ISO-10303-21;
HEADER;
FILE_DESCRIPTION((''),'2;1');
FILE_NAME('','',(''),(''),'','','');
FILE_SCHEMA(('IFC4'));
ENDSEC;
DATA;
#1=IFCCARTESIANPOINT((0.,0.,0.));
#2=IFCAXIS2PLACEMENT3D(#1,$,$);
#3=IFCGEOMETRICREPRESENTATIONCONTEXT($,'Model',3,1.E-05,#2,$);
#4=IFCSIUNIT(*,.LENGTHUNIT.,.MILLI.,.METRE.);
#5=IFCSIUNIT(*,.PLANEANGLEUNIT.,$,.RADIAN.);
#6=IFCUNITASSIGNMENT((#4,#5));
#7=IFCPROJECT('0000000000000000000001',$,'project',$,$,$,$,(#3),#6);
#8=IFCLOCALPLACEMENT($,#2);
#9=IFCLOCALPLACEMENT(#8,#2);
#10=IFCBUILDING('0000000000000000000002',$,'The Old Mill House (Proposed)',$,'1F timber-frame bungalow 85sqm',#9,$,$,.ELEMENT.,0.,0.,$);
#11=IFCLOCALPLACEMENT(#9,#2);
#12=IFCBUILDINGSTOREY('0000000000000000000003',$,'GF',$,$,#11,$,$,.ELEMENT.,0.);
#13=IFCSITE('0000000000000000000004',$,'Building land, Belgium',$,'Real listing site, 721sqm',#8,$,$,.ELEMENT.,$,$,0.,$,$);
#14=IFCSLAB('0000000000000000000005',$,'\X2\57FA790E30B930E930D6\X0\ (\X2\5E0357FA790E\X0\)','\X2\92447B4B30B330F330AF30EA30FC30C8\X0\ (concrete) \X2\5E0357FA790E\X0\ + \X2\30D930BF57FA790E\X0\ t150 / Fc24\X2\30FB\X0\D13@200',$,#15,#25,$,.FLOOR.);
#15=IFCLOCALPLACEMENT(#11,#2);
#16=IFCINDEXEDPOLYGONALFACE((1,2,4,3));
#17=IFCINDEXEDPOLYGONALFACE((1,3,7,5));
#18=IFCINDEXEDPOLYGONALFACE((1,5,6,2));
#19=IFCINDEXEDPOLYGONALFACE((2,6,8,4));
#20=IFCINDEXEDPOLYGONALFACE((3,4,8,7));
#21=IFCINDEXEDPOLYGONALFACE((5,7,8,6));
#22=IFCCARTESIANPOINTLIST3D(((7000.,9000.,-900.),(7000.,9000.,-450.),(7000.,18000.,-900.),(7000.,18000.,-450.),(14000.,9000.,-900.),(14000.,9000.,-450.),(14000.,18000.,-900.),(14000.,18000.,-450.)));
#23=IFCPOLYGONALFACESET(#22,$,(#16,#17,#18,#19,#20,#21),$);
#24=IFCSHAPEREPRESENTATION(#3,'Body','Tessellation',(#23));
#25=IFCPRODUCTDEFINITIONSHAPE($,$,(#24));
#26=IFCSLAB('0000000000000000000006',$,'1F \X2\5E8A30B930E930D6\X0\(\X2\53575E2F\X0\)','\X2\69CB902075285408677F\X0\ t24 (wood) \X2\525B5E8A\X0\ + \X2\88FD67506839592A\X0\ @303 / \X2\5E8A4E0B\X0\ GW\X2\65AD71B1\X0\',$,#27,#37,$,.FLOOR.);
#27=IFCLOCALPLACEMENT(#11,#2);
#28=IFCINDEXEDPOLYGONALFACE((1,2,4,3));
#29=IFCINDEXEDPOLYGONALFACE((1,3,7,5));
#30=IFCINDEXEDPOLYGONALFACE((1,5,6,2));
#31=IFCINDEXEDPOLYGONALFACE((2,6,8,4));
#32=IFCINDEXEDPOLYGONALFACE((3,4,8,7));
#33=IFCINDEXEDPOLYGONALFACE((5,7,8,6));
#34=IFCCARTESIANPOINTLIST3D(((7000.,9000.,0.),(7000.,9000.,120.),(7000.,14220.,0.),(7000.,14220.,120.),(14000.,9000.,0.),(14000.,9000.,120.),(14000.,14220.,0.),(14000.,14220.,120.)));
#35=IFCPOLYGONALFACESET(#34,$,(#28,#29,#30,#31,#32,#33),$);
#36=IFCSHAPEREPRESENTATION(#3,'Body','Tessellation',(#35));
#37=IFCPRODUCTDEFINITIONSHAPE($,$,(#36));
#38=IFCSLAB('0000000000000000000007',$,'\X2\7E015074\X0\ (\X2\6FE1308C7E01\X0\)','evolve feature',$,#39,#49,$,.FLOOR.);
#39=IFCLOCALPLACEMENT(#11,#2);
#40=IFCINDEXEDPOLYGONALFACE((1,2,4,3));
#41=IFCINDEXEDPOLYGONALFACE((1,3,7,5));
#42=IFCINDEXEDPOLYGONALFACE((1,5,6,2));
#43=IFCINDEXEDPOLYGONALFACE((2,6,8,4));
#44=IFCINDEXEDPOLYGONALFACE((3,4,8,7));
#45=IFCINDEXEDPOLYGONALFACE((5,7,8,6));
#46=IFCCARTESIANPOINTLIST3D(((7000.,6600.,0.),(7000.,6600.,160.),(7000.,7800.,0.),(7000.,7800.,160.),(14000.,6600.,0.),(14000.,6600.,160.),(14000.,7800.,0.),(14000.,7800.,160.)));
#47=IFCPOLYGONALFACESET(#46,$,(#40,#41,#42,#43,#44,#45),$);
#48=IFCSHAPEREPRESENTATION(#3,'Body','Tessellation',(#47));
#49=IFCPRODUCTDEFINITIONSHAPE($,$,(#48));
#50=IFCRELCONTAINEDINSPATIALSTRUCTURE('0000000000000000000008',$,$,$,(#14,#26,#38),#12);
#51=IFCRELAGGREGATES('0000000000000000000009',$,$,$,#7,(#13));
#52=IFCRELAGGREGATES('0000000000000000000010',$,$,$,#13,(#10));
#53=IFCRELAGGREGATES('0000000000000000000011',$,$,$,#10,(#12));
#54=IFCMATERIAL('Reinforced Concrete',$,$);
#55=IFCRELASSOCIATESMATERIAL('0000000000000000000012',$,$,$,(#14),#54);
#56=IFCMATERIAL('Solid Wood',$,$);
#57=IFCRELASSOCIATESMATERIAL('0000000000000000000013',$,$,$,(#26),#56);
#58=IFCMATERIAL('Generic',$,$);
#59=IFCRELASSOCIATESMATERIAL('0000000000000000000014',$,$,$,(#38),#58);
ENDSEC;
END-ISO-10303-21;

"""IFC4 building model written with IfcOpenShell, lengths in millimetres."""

from ifc_helpers import new_model, si_unit, frame, frame_2d, origin, place, context, project, spatial, rectangle, extrude, material, element, save


model = new_model("IFC4")

# Units and contexts
model_context = context("Model", 3, precision=1e-05, world=origin())
ifc_project = project(units=[si_unit("LENGTHUNIT", "METRE", prefix="MILLI"), si_unit("PLANEANGLEUNIT", "RADIAN")], contexts=[model_context])

# Site, building, storey
site_placement = place(None, origin())
site = spatial("IfcSite", under=ifc_project, at=site_placement, Name="Building land, Belgium", ObjectType="Real listing site, 721sqm", CompositionType="ELEMENT", RefElevation=0.0)
building_placement = place(site_placement, origin())
building = spatial("IfcBuilding", under=site, at=building_placement, Name="The Old Mill House (Proposed)", ObjectType="1F timber-frame bungalow 85sqm", CompositionType="ELEMENT", ElevationOfRefHeight=0.0, ElevationOfTerrain=0.0)
storey_placement = place(building_placement, origin())
storey = spatial("IfcBuildingStorey", under=building, at=storey_placement, Name="GF", CompositionType="ELEMENT", Elevation=0.0)

# Slabs
ifc_material_1 = material(Name="Reinforced Concrete")
slab_1_placement = place(storey_placement, frame((3500.0, 4500.0, -450.0)))
element("IfcSlab", 1, at=slab_1_placement, inside=storey, material=ifc_material_1, Name="基礎スラブ (布基礎)", Description="鉄筋コンクリート (concrete) 布基礎 + ベタ基礎 t150 / Fc24・D13@200", PredefinedType="FLOOR", context=model_context, shape_type="SweptSolid", body=[
    extrude(rectangle(XDim=7000.0, YDim=9000.0, at=frame_2d((3500.0, 4500.0))), frame((3500.0, 4500.0, -450.0)), (0.0, 0.0, 1.0), 450.0),
])
ifc_material_2 = material(Name="Solid Wood")
slab_2_placement = place(storey_placement, frame((3500.0, 4500.0, 0.0)))
element("IfcSlab", 2, at=slab_2_placement, inside=storey, material=ifc_material_2, Name="1F 床スラブ(南帯)", Description="構造用合板 t24 (wood) 剛床 + 製材根太 @303 / 床下 GW断熱", PredefinedType="FLOOR", context=model_context, shape_type="SweptSolid", body=[
    extrude(rectangle(XDim=7000.0, YDim=5220.0, at=frame_2d((3500.0, 2610.0))), frame((3500.0, 4500.0, 0.0)), (0.0, 0.0, 1.0), 120.0),
])
ifc_material_3 = material(Name="Generic")
slab_3_placement = place(storey_placement, frame((3500.0, 3300.0, 0.0)))
element("IfcSlab", 3, at=slab_3_placement, inside=storey, material=ifc_material_3, Name="縁側 (濡れ縁)", Description="evolve feature", PredefinedType="FLOOR", context=model_context, shape_type="SweptSolid", body=[
    extrude(rectangle(XDim=7000.0, YDim=1200.0, at=frame_2d((3500.0, 600.0))), frame((3500.0, 3300.0, 0.0)), (0.0, 0.0, 1.0), 160.0),
])

save(model, "model.ifc")
